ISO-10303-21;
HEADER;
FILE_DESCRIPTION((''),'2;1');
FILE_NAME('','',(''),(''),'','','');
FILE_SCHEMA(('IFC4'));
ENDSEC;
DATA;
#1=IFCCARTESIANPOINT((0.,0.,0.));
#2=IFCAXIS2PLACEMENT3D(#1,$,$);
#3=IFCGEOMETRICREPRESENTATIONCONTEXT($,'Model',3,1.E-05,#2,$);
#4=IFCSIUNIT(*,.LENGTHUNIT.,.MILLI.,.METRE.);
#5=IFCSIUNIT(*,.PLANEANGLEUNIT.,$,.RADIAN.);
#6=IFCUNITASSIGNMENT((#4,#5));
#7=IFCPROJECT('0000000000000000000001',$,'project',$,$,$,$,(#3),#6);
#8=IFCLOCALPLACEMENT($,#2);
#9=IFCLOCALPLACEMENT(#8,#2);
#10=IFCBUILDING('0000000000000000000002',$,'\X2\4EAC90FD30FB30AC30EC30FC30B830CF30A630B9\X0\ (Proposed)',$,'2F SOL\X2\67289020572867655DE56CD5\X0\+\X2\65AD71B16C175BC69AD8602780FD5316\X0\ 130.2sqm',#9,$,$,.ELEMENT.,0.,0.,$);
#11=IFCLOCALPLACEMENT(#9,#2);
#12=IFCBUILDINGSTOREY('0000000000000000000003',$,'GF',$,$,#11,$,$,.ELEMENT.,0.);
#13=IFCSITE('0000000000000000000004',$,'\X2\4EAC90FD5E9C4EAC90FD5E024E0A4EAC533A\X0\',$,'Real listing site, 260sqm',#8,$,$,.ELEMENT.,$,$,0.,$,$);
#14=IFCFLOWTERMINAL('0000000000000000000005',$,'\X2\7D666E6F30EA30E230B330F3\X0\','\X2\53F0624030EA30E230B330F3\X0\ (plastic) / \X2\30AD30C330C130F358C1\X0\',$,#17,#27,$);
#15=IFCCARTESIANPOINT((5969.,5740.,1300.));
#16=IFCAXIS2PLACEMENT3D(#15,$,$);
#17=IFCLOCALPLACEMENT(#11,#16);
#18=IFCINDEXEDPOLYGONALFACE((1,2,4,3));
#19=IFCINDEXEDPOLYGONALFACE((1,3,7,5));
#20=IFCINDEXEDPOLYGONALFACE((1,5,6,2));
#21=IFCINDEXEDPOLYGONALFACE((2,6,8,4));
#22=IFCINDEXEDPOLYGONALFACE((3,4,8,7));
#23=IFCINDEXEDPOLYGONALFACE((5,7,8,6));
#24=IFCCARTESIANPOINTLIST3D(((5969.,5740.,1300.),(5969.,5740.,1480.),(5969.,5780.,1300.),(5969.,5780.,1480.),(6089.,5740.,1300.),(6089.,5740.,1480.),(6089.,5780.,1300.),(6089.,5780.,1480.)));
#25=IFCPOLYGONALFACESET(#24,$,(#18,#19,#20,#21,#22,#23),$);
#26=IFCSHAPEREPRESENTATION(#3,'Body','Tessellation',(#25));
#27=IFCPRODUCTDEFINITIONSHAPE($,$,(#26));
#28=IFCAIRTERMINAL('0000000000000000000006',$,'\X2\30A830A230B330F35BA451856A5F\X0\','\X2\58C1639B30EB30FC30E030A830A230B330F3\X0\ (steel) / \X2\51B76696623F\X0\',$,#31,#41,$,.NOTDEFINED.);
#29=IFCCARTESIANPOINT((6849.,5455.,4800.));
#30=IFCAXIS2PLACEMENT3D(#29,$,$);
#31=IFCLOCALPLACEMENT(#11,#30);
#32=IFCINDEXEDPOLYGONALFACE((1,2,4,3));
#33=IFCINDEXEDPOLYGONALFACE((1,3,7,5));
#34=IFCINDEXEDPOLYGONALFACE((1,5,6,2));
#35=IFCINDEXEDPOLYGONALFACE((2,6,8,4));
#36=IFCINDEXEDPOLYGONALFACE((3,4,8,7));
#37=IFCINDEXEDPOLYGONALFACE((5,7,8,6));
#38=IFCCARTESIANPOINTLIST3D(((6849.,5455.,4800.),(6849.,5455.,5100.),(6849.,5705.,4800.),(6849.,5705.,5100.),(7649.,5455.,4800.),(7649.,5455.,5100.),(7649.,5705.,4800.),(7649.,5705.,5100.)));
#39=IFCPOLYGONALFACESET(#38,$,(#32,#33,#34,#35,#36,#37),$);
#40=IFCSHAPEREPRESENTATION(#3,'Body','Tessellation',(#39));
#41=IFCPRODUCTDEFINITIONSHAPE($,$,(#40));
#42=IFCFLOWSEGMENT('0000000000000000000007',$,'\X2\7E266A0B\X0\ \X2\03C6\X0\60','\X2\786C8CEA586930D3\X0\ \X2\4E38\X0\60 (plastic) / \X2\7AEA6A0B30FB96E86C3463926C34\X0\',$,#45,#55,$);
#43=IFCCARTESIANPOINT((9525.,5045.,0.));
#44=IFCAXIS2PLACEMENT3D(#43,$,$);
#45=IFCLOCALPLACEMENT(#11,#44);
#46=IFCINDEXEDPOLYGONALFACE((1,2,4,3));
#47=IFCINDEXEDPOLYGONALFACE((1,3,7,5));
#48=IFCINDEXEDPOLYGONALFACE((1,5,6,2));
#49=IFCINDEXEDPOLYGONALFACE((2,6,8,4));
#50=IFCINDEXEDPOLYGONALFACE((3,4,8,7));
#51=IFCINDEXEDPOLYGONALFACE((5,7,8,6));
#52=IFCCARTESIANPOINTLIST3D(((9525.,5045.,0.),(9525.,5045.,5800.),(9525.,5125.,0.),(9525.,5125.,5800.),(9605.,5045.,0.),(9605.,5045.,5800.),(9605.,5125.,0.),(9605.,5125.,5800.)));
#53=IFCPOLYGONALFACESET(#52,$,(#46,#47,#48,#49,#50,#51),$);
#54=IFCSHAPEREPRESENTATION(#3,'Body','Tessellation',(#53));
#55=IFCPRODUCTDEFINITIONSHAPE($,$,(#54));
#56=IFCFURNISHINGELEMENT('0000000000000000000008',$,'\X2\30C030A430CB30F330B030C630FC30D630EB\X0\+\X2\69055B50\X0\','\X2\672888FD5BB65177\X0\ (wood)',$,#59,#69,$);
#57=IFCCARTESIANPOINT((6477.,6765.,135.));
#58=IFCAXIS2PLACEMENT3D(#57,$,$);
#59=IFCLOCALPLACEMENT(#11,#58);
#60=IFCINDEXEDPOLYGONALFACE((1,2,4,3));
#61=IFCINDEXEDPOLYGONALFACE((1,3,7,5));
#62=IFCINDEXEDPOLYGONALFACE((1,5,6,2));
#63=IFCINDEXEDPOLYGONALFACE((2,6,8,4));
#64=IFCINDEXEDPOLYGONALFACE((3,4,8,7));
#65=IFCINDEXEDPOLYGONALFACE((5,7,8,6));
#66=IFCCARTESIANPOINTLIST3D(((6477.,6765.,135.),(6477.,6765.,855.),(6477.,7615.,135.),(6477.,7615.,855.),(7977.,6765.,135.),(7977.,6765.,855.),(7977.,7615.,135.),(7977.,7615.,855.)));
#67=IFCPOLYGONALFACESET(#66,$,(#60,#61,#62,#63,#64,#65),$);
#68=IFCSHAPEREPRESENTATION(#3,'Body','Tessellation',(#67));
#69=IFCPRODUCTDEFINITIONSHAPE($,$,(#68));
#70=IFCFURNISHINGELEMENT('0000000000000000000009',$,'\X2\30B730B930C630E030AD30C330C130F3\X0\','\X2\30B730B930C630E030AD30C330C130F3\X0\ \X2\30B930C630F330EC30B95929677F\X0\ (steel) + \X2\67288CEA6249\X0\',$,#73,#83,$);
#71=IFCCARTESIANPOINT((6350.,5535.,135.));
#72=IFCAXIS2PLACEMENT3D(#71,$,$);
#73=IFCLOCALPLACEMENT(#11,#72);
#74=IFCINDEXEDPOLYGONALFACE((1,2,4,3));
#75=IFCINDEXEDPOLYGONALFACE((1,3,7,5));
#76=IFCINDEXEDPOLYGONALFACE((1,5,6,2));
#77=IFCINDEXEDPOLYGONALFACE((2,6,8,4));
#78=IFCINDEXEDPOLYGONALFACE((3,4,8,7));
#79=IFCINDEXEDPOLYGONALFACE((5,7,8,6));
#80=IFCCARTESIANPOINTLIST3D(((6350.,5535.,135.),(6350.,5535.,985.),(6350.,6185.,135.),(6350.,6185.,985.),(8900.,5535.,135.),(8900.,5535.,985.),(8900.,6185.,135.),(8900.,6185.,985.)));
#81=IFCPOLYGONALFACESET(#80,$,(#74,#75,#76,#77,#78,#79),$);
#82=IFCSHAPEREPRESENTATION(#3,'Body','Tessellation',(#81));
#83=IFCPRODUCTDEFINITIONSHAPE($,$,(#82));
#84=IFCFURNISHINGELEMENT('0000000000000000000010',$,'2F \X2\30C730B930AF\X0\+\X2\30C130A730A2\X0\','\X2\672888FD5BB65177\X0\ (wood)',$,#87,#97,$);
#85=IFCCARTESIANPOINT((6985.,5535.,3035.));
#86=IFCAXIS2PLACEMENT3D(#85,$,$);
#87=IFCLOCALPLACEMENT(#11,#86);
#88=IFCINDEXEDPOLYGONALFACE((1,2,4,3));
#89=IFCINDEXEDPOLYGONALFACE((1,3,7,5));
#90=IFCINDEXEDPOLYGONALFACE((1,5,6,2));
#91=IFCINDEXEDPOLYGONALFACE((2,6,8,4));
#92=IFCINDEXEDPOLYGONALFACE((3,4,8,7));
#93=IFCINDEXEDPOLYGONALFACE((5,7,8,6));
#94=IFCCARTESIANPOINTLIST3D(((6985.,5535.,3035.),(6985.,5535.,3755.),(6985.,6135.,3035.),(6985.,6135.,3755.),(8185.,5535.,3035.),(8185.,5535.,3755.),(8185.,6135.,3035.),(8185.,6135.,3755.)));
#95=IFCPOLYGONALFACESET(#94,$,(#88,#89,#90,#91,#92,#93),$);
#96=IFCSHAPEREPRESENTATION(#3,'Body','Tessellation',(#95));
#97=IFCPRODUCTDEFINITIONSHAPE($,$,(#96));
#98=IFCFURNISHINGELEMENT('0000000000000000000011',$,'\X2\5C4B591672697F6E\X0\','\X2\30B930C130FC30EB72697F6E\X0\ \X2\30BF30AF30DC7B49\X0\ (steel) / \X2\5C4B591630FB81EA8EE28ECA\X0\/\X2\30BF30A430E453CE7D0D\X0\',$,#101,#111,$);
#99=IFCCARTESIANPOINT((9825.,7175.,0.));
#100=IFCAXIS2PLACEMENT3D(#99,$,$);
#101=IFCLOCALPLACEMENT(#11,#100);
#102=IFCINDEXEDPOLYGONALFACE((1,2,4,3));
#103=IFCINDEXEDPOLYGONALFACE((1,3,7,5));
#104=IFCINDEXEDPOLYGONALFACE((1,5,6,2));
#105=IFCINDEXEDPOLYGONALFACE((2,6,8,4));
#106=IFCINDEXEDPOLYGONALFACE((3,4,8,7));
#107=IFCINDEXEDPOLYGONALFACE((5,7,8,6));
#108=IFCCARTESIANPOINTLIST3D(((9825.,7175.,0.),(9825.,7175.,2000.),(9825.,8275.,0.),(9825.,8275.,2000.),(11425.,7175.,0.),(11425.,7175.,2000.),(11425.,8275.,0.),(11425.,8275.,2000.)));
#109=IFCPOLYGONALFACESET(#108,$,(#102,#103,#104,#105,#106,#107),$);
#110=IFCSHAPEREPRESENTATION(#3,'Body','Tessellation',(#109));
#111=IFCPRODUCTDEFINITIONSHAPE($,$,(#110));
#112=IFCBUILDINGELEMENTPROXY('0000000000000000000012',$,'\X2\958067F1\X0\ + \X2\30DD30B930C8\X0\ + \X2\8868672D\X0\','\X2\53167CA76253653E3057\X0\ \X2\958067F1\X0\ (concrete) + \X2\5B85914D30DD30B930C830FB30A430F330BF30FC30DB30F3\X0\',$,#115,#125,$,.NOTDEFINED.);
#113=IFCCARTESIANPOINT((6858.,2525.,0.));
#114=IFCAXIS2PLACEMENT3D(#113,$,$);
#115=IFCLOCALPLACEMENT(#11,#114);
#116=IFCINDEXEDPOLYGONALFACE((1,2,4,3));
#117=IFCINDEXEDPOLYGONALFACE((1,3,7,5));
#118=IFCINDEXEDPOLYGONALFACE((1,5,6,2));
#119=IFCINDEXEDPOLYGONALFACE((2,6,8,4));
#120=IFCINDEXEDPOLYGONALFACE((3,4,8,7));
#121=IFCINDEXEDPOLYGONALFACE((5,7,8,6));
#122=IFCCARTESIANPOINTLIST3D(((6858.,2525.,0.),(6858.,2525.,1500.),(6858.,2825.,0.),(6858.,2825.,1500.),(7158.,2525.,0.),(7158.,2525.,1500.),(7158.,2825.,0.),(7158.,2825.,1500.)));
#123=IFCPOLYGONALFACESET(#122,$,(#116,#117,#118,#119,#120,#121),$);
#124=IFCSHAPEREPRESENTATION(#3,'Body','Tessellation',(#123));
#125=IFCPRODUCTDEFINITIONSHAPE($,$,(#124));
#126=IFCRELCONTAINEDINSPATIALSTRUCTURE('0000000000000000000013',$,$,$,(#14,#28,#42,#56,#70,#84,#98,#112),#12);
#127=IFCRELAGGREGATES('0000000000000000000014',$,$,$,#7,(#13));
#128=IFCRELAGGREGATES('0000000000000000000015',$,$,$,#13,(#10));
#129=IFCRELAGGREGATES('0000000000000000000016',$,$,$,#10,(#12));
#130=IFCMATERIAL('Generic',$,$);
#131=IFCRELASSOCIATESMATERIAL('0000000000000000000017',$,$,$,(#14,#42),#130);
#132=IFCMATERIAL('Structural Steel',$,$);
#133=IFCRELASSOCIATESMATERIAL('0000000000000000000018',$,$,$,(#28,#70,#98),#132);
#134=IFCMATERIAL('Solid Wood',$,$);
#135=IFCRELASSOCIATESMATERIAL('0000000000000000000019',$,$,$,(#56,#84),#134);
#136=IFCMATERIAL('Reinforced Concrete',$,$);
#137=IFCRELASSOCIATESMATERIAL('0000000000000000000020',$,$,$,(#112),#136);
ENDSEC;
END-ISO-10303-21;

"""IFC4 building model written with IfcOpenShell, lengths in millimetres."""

from ifc_helpers import new_model, si_unit, frame, frame_2d, origin, place, context, project, spatial, rectangle, extrude, material, element, save


model = new_model("IFC4")

# Units and contexts
model_context = context("Model", 3, precision=1e-05, world=origin())
ifc_project = project(units=[si_unit("LENGTHUNIT", "METRE", prefix="MILLI"), si_unit("PLANEANGLEUNIT", "RADIAN")], contexts=[model_context])

# Site, building, storey
site_placement = place(None, origin())
site = spatial("IfcSite", under=ifc_project, at=site_placement, Name="京都府京都市上京区", ObjectType="Real listing site, 260sqm", CompositionType="ELEMENT", RefElevation=0.0)
building_placement = place(site_placement, origin())
building = spatial("IfcBuilding", under=site, at=building_placement, Name="京都・ガレージハウス (Proposed)", ObjectType="2F SOL木造在来工法+断熱気密高性能化 130.2sqm", CompositionType="ELEMENT", ElevationOfRefHeight=0.0, ElevationOfTerrain=0.0)
storey_placement = place(building_placement, origin())
storey = spatial("IfcBuildingStorey", under=building, at=storey_placement, Name="GF", CompositionType="ELEMENT", Elevation=0.0)

# Shared definitions
ifc_material_1 = material(Name="Solid Wood")
ifc_material_2 = material(Name="Structural Steel")

# Shared definitions
ifc_material_3 = material(Name="Reinforced Concrete")

# Flow terminal
ifc_material_4 = material(Name="Generic")
flow_terminal_1_placement = place(storey_placement, frame((5969.0, 5740.0, 1300.0)))
element("IfcFlowTerminal", 1, at=flow_terminal_1_placement, inside=storey, material=ifc_material_4, Name="給湯リモコン", Description="台所リモコン (plastic) / キッチン壁", context=model_context, shape_type="SweptSolid", body=[
    extrude(rectangle(XDim=120.0, YDim=40.0, at=frame_2d((60.0, 20.0))), frame((5969.0, 5740.0, 1300.0)), (0.0, 0.0, 1.0), 180.0),
])

# Air terminal
air_terminal_placement = place(storey_placement, frame((6849.0, 5455.0, 4800.0)))
element("IfcAirTerminal", 2, at=air_terminal_placement, inside=storey, material=ifc_material_2, Name="エアコン室内機", Description="壁掛ルームエアコン (steel) / 冷暖房", PredefinedType="NOTDEFINED", context=model_context, shape_type="SweptSolid", body=[
    extrude(rectangle(XDim=800.0, YDim=250.0, at=frame_2d((400.0, 125.0))), frame((6849.0, 5455.0, 4800.0)), (0.0, 0.0, 1.0), 300.0),
])

# Flow segment
flow_segment_placement = place(storey_placement, frame((9525.0, 5045.0, 0.0)))
element("IfcFlowSegment", 3, at=flow_segment_placement, inside=storey, material=ifc_material_4, Name="縦樋 φ60", Description="硬質塩ビ 丸60 (plastic) / 竪樋・雨水排水", context=model_context, shape_type="SweptSolid", body=[
    extrude(rectangle(XDim=80.0, YDim=80.0, at=frame_2d((40.0, 40.0))), frame((9525.0, 5045.0, 0.0)), (0.0, 0.0, 1.0), 5800.0),
])

# Furnishing elements
furnishing_1_placement = place(storey_placement, frame((6477.0, 6765.0, 135.0)))
element("IfcFurnishingElement", 4, at=furnishing_1_placement, inside=storey, material=ifc_material_1, Name="ダイニングテーブル+椅子", Description="木製家具 (wood)", context=model_context, shape_type="SweptSolid", body=[
    extrude(rectangle(XDim=1500.0, YDim=850.0, at=frame_2d((750.0, 425.0))), frame((6477.0, 6765.0, 135.0)), (0.0, 0.0, 1.0), 720.0),
])
furnishing_2_placement = place(storey_placement, frame((6350.0, 5535.0, 135.0)))
element("IfcFurnishingElement", 5, at=furnishing_2_placement, inside=storey, material=ifc_material_2, Name="システムキッチン", Description="システムキッチン ステンレス天板 (steel) + 木質扉", context=model_context, shape_type="SweptSolid", body=[
    extrude(rectangle(XDim=2550.0, YDim=650.0, at=frame_2d((1275.0, 325.0))), frame((6350.0, 5535.0, 135.0)), (0.0, 0.0, 1.0), 850.0),
])
furnishing_3_placement = place(storey_placement, frame((6985.0, 5535.0, 3035.0)))
element("IfcFurnishingElement", 6, at=furnishing_3_placement, inside=storey, material=ifc_material_1, Name="2F デスク+チェア", Description="木製家具 (wood)", context=model_context, shape_type="SweptSolid", body=[
    extrude(rectangle(XDim=1200.0, YDim=600.0, at=frame_2d((600.0, 300.0))), frame((6985.0, 5535.0, 3035.0)), (0.0, 0.0, 1.0), 720.0),
])
furnishing_4_placement = place(storey_placement, frame((9825.0, 7175.0, 0.0)))
element("IfcFurnishingElement", 7, at=furnishing_4_placement, inside=storey, material=ifc_material_2, Name="屋外物置", Description="スチール物置 タクボ等 (steel) / 屋外・自転車/タイヤ収納", context=model_context, shape_type="SweptSolid", body=[
    extrude(rectangle(XDim=1600.0, YDim=1100.0, at=frame_2d((800.0, 550.0))), frame((9825.0, 7175.0, 0.0)), (0.0, 0.0, 1.0), 2000.0),
])

# Building element proxy
proxy_placement = place(storey_placement, frame((6858.0, 2525.0, 0.0)))
element("IfcBuildingElementProxy", 8, at=proxy_placement, inside=storey, material=ifc_material_3, Name="門柱 + ポスト + 表札", Description="化粧打放し 門柱 (concrete) + 宅配ポスト・インターホン", PredefinedType="NOTDEFINED", context=model_context, shape_type="SweptSolid", body=[
    extrude(rectangle(XDim=300.0, YDim=300.0, at=frame_2d((150.0, 150.0))), frame((6858.0, 2525.0, 0.0)), (0.0, 0.0, 1.0), 1500.0),
])

save(model, "model.ifc")
